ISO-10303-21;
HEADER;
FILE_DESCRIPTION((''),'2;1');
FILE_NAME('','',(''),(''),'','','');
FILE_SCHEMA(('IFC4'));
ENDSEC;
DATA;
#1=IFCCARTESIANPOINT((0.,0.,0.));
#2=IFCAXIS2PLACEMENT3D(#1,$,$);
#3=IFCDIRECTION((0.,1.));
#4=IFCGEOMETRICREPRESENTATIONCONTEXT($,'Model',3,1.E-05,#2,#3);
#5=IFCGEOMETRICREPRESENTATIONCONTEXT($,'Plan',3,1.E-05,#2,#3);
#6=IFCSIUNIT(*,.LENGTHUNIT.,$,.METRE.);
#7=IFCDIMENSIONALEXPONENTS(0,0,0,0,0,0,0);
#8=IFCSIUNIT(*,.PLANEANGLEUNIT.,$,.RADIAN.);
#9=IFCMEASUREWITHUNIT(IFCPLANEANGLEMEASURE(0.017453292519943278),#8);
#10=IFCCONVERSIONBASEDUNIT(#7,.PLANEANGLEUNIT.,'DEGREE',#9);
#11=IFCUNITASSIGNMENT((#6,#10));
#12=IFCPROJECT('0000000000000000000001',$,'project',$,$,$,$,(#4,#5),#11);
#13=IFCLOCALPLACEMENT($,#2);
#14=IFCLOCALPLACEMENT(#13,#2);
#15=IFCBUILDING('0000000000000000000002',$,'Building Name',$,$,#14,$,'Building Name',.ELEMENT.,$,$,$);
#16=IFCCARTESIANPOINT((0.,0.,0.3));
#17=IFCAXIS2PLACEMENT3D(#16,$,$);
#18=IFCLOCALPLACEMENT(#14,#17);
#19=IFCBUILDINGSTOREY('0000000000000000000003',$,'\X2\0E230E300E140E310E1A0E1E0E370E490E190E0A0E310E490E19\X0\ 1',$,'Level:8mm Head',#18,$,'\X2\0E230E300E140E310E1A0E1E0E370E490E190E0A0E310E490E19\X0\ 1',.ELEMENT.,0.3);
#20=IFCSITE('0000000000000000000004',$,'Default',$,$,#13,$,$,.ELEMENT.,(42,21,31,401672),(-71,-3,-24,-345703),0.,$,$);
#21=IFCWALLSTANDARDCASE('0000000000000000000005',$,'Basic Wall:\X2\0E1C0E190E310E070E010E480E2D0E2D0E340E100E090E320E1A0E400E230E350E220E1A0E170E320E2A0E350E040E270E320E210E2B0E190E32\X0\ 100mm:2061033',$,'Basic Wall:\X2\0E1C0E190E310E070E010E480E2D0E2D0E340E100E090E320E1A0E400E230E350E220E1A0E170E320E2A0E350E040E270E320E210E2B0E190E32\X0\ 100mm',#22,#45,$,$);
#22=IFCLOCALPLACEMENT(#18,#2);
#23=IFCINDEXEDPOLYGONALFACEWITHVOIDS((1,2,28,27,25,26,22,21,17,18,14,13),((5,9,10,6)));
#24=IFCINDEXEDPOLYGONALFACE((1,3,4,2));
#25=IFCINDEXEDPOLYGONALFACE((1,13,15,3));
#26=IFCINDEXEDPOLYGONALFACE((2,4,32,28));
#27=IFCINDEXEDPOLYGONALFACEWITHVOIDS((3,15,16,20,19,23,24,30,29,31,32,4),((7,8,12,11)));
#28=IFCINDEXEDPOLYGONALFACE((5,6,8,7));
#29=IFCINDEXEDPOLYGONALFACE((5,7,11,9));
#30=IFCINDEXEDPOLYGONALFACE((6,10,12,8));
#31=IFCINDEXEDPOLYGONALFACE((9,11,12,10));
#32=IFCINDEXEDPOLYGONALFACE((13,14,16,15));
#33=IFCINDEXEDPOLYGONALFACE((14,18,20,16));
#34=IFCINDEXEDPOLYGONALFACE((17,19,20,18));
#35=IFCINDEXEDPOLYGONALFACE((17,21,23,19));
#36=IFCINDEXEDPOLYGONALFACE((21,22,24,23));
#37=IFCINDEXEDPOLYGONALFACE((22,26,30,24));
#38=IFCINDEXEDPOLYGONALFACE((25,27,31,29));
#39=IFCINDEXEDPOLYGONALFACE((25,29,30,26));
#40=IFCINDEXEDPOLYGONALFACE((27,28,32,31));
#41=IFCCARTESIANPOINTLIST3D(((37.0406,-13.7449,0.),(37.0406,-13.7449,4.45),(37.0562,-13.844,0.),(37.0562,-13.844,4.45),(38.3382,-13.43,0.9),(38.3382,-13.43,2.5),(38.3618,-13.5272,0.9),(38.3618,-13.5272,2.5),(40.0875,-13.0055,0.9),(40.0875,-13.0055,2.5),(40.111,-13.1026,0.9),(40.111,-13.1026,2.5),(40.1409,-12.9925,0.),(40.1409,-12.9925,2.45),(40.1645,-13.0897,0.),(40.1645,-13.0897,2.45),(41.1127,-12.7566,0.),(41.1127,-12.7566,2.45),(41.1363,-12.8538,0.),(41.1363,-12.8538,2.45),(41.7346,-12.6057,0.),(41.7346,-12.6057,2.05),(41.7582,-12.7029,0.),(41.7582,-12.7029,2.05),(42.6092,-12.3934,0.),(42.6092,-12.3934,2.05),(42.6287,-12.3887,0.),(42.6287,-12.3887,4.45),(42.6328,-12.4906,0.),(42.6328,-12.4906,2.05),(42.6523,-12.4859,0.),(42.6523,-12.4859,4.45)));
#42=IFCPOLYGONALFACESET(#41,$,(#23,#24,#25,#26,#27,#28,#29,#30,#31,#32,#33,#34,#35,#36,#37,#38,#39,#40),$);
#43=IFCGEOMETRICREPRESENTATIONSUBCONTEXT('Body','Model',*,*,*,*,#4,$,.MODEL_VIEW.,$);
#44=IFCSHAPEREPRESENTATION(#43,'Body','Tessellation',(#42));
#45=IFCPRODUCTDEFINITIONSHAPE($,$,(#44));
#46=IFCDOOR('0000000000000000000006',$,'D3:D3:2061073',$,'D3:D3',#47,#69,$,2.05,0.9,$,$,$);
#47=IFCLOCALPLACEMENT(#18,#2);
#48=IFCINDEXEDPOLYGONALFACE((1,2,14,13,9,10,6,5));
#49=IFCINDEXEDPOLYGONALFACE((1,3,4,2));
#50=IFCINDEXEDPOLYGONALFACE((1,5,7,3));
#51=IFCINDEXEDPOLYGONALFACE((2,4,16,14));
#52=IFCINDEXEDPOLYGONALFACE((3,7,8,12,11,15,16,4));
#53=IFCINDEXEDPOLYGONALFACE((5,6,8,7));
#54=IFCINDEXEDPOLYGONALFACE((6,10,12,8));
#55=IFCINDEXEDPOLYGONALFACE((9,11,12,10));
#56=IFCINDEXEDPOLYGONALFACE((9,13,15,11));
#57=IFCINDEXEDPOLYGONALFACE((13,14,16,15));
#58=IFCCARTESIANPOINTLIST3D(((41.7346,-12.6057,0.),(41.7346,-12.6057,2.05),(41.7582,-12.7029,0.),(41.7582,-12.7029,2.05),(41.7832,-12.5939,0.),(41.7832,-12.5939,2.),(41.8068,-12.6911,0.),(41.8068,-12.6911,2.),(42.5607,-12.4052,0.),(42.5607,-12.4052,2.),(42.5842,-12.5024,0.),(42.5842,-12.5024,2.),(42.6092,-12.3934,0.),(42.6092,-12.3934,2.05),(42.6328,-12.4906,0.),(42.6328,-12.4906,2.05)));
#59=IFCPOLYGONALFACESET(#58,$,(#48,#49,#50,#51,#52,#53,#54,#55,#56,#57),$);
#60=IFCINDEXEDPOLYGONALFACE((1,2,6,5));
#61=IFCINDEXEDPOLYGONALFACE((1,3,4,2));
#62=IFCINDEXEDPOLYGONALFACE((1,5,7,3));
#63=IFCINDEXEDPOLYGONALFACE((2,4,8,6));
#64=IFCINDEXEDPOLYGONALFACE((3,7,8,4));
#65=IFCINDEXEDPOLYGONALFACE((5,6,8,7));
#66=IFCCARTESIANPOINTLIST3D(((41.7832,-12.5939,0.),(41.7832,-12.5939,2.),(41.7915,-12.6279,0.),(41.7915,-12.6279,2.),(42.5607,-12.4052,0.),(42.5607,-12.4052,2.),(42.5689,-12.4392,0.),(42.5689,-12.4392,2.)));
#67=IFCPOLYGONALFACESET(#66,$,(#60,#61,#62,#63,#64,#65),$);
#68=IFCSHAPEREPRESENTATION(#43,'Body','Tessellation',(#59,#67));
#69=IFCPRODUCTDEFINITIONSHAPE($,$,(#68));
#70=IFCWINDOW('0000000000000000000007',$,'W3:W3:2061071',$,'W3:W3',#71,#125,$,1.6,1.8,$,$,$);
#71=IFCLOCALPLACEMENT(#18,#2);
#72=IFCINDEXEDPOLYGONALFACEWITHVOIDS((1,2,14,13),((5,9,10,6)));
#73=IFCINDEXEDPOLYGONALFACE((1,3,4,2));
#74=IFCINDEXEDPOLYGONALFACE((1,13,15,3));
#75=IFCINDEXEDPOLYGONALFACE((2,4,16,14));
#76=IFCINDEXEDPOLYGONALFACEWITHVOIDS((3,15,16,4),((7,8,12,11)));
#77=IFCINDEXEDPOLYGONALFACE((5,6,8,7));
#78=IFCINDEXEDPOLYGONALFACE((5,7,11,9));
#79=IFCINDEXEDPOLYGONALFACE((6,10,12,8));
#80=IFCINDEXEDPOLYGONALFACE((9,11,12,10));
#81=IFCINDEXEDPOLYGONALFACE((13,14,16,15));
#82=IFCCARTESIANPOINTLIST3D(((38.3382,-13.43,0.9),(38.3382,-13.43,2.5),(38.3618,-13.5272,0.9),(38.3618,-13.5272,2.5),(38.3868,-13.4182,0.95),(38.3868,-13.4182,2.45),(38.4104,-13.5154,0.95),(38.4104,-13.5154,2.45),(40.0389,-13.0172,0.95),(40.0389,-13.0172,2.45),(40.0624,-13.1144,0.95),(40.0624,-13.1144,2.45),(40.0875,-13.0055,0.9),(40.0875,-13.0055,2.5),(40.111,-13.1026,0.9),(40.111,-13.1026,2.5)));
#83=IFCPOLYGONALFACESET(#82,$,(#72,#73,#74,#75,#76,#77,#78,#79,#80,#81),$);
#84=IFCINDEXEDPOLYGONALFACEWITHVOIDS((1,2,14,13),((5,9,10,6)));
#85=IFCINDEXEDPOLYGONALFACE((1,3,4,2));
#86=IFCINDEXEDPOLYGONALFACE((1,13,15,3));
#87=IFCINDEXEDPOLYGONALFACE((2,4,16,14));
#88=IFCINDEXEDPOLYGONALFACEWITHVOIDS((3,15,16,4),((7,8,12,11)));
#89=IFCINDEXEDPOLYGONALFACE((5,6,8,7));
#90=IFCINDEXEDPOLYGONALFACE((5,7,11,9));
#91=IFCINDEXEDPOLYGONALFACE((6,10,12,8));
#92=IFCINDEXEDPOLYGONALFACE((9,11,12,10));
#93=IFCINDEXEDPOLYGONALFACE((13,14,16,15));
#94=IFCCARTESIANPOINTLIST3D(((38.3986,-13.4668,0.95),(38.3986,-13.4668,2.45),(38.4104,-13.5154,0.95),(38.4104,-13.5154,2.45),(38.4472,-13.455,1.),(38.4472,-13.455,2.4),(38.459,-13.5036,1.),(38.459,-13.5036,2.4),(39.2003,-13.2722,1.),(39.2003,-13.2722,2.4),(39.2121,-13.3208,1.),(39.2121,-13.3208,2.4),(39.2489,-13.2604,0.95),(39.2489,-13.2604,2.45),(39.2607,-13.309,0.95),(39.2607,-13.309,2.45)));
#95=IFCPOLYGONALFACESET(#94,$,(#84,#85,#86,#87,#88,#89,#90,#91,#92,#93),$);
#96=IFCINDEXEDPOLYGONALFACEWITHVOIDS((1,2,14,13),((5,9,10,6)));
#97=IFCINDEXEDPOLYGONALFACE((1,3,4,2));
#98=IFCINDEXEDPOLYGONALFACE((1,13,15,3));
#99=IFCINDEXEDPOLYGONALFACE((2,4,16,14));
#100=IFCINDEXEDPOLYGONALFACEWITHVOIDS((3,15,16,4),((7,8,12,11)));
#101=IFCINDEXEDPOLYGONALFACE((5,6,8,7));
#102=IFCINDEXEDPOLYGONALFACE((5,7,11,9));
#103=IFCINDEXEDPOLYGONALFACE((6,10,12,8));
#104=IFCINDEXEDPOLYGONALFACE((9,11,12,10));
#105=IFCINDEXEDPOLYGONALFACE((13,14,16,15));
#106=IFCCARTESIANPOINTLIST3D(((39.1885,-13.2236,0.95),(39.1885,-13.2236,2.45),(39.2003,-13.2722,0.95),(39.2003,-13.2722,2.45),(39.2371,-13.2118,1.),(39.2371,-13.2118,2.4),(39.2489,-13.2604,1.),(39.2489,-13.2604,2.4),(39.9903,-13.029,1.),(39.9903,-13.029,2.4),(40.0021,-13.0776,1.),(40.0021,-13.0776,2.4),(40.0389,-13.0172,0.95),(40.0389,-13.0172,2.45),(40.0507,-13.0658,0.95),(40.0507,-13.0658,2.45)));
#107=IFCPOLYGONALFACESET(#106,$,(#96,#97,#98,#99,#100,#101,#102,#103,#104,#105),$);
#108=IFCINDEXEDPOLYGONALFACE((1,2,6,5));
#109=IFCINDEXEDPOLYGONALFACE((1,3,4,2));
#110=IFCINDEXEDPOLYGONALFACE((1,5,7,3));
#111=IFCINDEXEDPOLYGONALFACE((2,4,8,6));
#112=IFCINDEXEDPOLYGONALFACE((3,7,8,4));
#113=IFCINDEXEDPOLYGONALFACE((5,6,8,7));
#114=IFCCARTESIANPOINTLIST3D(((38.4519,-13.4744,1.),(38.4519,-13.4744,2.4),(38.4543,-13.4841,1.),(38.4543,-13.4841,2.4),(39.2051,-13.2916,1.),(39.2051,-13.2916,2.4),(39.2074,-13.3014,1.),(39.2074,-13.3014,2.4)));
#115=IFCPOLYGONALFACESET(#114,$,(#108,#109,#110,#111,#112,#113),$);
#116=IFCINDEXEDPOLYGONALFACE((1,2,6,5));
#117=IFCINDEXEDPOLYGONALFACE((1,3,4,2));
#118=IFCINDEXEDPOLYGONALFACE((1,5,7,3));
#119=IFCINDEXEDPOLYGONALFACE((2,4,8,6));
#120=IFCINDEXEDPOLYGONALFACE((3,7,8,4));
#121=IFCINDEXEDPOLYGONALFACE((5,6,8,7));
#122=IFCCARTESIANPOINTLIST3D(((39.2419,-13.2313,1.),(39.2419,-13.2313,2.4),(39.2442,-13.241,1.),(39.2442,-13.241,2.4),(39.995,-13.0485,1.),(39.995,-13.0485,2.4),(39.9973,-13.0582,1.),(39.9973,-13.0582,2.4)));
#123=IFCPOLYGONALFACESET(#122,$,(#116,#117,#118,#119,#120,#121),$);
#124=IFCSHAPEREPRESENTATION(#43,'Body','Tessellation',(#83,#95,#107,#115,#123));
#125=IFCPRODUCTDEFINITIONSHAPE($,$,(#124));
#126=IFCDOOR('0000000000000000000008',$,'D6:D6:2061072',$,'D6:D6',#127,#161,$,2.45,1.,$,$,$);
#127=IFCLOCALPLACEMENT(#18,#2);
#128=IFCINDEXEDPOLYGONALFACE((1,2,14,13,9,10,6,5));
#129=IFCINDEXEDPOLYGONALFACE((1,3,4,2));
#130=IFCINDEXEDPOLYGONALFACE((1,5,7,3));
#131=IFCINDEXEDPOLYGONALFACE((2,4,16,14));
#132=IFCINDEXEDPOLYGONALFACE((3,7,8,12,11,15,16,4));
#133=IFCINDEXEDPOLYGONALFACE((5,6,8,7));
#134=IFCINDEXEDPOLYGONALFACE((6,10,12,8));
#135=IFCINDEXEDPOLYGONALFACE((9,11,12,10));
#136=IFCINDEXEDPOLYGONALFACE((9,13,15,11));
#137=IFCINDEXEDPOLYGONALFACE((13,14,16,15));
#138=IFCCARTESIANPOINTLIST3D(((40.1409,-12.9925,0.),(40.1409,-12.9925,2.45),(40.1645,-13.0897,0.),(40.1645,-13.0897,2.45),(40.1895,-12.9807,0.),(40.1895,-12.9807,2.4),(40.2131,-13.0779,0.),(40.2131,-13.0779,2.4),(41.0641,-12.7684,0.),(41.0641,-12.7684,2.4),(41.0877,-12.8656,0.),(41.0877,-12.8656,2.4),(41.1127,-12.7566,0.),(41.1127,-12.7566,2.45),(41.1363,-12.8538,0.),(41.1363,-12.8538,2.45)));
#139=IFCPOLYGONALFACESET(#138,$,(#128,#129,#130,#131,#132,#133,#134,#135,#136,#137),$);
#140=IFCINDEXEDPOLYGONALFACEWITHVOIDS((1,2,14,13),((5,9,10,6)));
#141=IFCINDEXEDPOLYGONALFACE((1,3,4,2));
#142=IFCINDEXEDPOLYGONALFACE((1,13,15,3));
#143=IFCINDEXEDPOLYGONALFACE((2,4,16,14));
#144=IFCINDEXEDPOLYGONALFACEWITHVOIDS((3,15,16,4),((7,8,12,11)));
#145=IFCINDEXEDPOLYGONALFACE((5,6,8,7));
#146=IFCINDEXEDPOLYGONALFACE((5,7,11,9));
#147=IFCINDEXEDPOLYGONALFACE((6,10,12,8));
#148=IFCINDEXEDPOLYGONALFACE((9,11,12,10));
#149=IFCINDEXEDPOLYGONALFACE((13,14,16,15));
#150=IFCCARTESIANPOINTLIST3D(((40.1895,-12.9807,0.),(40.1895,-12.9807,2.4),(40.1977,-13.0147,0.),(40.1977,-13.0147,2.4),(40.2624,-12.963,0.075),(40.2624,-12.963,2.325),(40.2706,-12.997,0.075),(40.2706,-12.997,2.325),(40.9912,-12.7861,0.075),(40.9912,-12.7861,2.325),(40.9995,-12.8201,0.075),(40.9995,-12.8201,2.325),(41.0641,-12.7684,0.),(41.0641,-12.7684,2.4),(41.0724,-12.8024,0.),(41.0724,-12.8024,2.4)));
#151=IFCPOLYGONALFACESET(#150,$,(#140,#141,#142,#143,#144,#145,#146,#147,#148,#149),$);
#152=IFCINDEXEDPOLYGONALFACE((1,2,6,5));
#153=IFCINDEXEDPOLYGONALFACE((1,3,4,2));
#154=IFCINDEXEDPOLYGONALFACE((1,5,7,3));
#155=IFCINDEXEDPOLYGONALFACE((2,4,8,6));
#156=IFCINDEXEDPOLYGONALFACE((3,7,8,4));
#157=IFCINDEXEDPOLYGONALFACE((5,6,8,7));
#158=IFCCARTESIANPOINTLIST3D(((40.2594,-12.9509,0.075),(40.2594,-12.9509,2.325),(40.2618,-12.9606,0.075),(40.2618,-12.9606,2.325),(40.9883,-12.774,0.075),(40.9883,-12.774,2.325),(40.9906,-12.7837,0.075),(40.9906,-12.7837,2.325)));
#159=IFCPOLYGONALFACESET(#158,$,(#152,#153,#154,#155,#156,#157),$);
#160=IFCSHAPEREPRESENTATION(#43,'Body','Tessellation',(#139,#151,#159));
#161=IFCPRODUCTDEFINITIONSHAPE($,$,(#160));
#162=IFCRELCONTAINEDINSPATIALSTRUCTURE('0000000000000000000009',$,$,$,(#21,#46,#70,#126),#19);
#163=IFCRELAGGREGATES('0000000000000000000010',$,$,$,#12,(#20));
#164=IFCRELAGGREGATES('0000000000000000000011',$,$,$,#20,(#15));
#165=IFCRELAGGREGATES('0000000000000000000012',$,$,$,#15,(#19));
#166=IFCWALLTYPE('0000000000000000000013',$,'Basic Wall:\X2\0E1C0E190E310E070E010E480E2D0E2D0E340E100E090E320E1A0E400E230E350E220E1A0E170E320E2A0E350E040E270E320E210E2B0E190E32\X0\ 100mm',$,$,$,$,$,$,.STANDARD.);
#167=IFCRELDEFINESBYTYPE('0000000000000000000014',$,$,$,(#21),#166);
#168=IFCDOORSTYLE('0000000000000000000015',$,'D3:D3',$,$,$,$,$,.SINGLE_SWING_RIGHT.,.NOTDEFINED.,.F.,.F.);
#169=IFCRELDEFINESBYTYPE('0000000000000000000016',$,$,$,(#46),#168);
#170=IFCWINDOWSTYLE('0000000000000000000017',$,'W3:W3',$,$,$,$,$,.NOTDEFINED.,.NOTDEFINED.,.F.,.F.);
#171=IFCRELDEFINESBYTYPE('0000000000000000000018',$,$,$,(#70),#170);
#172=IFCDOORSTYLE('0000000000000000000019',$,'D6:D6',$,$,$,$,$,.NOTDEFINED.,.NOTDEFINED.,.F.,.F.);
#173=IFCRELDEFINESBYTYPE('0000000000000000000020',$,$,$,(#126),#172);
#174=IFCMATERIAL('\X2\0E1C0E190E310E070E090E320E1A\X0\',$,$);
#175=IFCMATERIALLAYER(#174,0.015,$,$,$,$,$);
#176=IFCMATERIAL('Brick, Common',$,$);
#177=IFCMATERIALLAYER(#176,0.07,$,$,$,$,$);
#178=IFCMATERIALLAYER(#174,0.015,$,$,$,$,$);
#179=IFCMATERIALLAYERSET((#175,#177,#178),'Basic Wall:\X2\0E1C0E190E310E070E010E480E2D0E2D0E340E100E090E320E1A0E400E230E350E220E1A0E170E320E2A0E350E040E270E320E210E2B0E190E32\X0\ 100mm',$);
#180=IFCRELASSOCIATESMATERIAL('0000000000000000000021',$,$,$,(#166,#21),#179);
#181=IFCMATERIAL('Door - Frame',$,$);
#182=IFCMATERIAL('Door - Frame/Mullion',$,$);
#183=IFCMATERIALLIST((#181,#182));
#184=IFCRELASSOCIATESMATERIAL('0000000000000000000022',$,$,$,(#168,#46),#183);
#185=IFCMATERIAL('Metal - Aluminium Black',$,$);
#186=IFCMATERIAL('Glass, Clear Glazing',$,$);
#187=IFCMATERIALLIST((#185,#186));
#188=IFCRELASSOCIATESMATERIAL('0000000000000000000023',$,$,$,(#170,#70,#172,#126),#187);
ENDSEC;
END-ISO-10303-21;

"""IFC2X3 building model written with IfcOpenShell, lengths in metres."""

from ifc_helpers import new_model, entity, si_unit, converted_unit, direction, frame, frame_2d, origin, origin_2d_with_axis, place, context, subcontext, project, spatial, polyline, rectangle, outline, extrude, clip, halfspace, source, transform, mapped, material, material_list, layer, layer_set, layer_usage, type_object, type_shapes, element, fill, save


model = new_model("IFC2X3")

# Units and contexts
model_context = context("Model", 3, precision=1e-05, world=origin(), true_north=direction((0.0, 1.0)))
plan_context = context("Plan", 3, precision=1e-05, world=origin(), true_north=direction((0.0, 1.0)))
body_context = subcontext(model_context, "Body", "Model", "MODEL_VIEW")
ifc_project = project(units=[si_unit("LENGTHUNIT", "METRE"), converted_unit("PLANEANGLEUNIT", "DEGREE", entity("IfcPlaneAngleMeasure", 0.017453292519943278), si_unit("PLANEANGLEUNIT", "RADIAN"), dimensions=[0, 0, 0, 0, 0, 0, 0])], contexts=[model_context, plan_context])

# Site, building, storey
site_placement = place(None, origin())
site = spatial("IfcSite", under=ifc_project, at=site_placement, Name="Default", CompositionType="ELEMENT", RefLatitude=(42, 21, 31, 401672), RefLongitude=(-71, -3, -24, -345703), RefElevation=0.0)
building_placement = place(site_placement, origin())
building = spatial("IfcBuilding", under=site, at=building_placement, Name="Building Name", LongName="Building Name", CompositionType="ELEMENT")
storey_placement = place(building_placement, frame((0.0, 0.0, 0.3)))
storey = spatial("IfcBuildingStorey", under=building, at=storey_placement, Name="ระดับพื้นชั้น 1", ObjectType="Level:8mm Head", LongName="ระดับพื้นชั้น 1", CompositionType="ELEMENT", Elevation=0.3)

# Shared definitions
ifc_material_1 = material(Name="Glass, Clear Glazing")

# Shared definitions
ifc_material_2 = material(Name="ผนังฉาบ")
ifc_layer_1 = layer(ifc_material_2, 0.015)
ifc_material_3 = material(Name="Brick, Common")
ifc_layer_2 = layer(ifc_material_3, 0.07)
ifc_layer_3 = layer(ifc_material_2, 0.015)
ifc_layer_set = layer_set([ifc_layer_1, ifc_layer_2, ifc_layer_3], Name="Basic Wall:ผนังก่ออิฐฉาบเรียบทาสีความหนา 100mm")
wall_type = type_object("IfcWallType", Name="Basic Wall:ผนังก่ออิฐฉาบเรียบทาสีความหนา 100mm", PredefinedType="STANDARD", material=ifc_layer_set)
ifc_material_4 = material(Name="Door - Frame")
ifc_material_5 = material(Name="Door - Frame/Mullion")
ifc_material_list_1 = material_list([ifc_material_4, ifc_material_5])
door_style_1 = type_object("IfcDoorStyle", Name="D3:D3", ConstructionType="NOTDEFINED", OperationType="SINGLE_SWING_RIGHT", ParameterTakesPrecedence=False, Sizeable=False, material=ifc_material_list_1)
shared_shape_1 = source(origin(), body_context, "Body", "SweptSolid", [
    extrude(outline(polyline([(-0.45, -1.0125), (-0.4, -1.0125), (-0.4, 0.9875), (0.4, 0.9875), (0.4, -1.0125), (0.45, -1.0125), (0.45, 1.0375), (-0.45, 1.0375), (-0.45, -1.0125)])), frame((0.45, 0.1, 1.0125), z_axis=(0.0, -1.0, 0.0), x_axis=(1.0, 0.0, 0.0)), (0.0, 0.0, 1.0), 0.1),
    extrude(rectangle(XDim=0.035, YDim=0.8, at=origin_2d_with_axis()), frame((0.45, 0.0825, 0.0), z_axis=(0.0, 0.0, 1.0), x_axis=(0.0, -1.0, 0.0)), (0.0, 0.0, 1.0), 2.0),
])
type_shapes(door_style_1, [shared_shape_1])

# Wall, openings, doors, window
ifc_layer_usage_1 = layer_usage(ifc_layer_set, "AXIS2", "POSITIVE", -0.05)
wall_1_placement = place(storey_placement, frame((37.0444, -13.7954, 0.0), z_axis=(0.0, 0.0, 1.0), x_axis=(0.97179, 0.235849, 0.0)))
wall_1 = element("IfcWallStandardCase", 1, at=wall_1_placement, inside=storey, type_object=wall_type, material=ifc_layer_usage_1, Name="Basic Wall:ผนังก่ออิฐฉาบเรียบทาสีความหนา 100mm:2061033", ObjectType="Basic Wall:ผนังก่ออิฐฉาบเรียบทาสีความหนา 100mm", context=body_context, shape_type="Clipping", body=[
    clip(extrude(outline(polyline([(5.7585, -0.05), (5.7585, 0.05), (4.3098, 0.05), (4.209, 0.05), (0.0082, 0.05), (0.0, -0.05), (5.7585, -0.05)])), origin(), (0.0, 0.0, 1.0), 4.45), halfspace(frame((0.0, 0.0, -0.15)), True)),
])
opening_1_placement = place(wall_1_placement, frame((4.8385, -0.05, 0.0)))
opening_1 = element("IfcOpeningElement", 2, at=opening_1_placement, cuts=wall_1, ObjectType="Opening", context=body_context, shape_type="SweptSolid", body=[
    extrude(rectangle(XDim=2.05, YDim=0.9, at=frame_2d((1.025, 0.45), x_axis=(1.0, 0.0))), frame((0.0, 0.0, 0.0), z_axis=(0.0, 1.0, 0.0), x_axis=(0.0, 0.0, 1.0)), (0.0, 0.0, 1.0), 0.1),
])
opening_2_placement = place(wall_1_placement, frame((3.1985, -0.05, 0.0)))
opening_2 = element("IfcOpeningElement", 3, at=opening_2_placement, cuts=wall_1, ObjectType="Opening", context=body_context, shape_type="SweptSolid", body=[
    extrude(rectangle(XDim=2.45, YDim=1.0, at=frame_2d((1.225, 0.5), x_axis=(1.0, 0.0))), frame((0.0, 0.0, 0.0), z_axis=(0.0, 1.0, 0.0), x_axis=(0.0, 0.0, 1.0)), (0.0, 0.0, 1.0), 0.1),
])
opening_3_placement = place(wall_1_placement, frame((3.1435, 0.05, 0.9)))
opening_3 = element("IfcOpeningElement", 4, at=opening_3_placement, cuts=wall_1, ObjectType="Opening", context=body_context, shape_type="SweptSolid", body=[
    extrude(rectangle(XDim=1.6, YDim=1.8, at=frame_2d((0.8, 0.9), x_axis=(1.0, 0.0))), frame((0.0, 0.0, 0.0), z_axis=(0.0, -1.0, 0.0), x_axis=(0.0, 0.0, 1.0)), (0.0, 0.0, 1.0), 0.1),
])
door_1_placement = place(opening_1_placement, origin())
door_1 = element("IfcDoor", 5, at=door_1_placement, inside=storey, type_object=door_style_1, material=ifc_material_list_1, Name="D3:D3:2061073", ObjectType="D3:D3", OverallHeight=2.05, OverallWidth=0.9, context=body_context, shape_type="MappedRepresentation", body=[
    mapped(shared_shape_1, transform((0.0, 0.0, 0.0), scale=1.0)),
])
fill(opening_1, door_1)
ifc_material_6 = material(Name="Metal - Aluminium Black")
ifc_material_list_2 = material_list([ifc_material_6, ifc_material_1])
window_style = type_object("IfcWindowStyle", Name="W3:W3", ConstructionType="NOTDEFINED", OperationType="NOTDEFINED", ParameterTakesPrecedence=False, Sizeable=False, material=ifc_material_list_2)
shared_shape_2 = source(origin(), body_context, "Body", "SweptSolid", [
    extrude(outline(polyline([(-0.8, -0.9), (0.8, -0.9), (0.8, 0.9), (-0.8, 0.9), (-0.8, -0.9)]), holes=[polyline([(0.75, -0.85), (-0.75, -0.85), (-0.75, 0.85), (0.75, 0.85), (0.75, -0.85)])]), frame((0.9, 0.0, 0.8), z_axis=(0.0, 1.0, 0.0), x_axis=(0.0, 0.0, 1.0)), (0.0, 0.0, 1.0), 0.1),
    extrude(outline(polyline([(-0.75, -0.4375), (0.75, -0.4375), (0.75, 0.4375), (-0.75, 0.4375), (-0.75, -0.4375)]), holes=[polyline([(0.7, -0.3875), (-0.7, -0.3875), (-0.7, 0.3875), (0.7, 0.3875), (0.7, -0.3875)])]), frame((1.3125, 0.05, 0.8), z_axis=(0.0, 1.0, 0.0), x_axis=(0.0, 0.0, -1.0)), (0.0, 0.0, 1.0), 0.05),
    extrude(outline(polyline([(-0.75, -0.4375), (0.75, -0.4375), (0.75, 0.4375), (-0.75, 0.4375), (-0.75, -0.4375)]), holes=[polyline([(0.7, -0.3875), (-0.7, -0.3875), (-0.7, 0.3875), (0.7, 0.3875), (0.7, -0.3875)])]), frame((0.4875, 0.0, 0.8), z_axis=(0.0, 1.0, 0.0), x_axis=(0.0, 0.0, -1.0)), (0.0, 0.0, 1.0), 0.05),
    extrude(rectangle(XDim=0.01, YDim=0.775, at=frame_2d((0.0, 0.0), x_axis=(1.0, 0.0))), frame((1.3125, 0.075, 0.1), z_axis=(0.0, 0.0, 1.0), x_axis=(0.0, -1.0, 0.0)), (0.0, 0.0, 1.0), 1.4),
    extrude(rectangle(XDim=0.01, YDim=0.775, at=frame_2d((0.0, 0.0), x_axis=(1.0, 0.0))), frame((0.4875, 0.025, 0.1), z_axis=(0.0, 0.0, 1.0), x_axis=(0.0, -1.0, 0.0)), (0.0, 0.0, 1.0), 1.4),
])
type_shapes(window_style, [shared_shape_2])
window_1_placement = place(opening_3_placement, frame((0.0, 0.0, 0.0), z_axis=(0.0, 0.0, 1.0), x_axis=(-1.0, 0.0, 0.0)))
window_1 = element("IfcWindow", 6, at=window_1_placement, inside=storey, type_object=window_style, material=ifc_material_list_2, Name="W3:W3:2061071", ObjectType="W3:W3", OverallHeight=1.6, OverallWidth=1.8, context=body_context, shape_type="MappedRepresentation", body=[
    mapped(shared_shape_2, transform((0.0, 0.0, 0.0), scale=1.0)),
])
fill(opening_3, window_1)
door_style_2 = type_object("IfcDoorStyle", Name="D6:D6", ConstructionType="NOTDEFINED", OperationType="NOTDEFINED", ParameterTakesPrecedence=False, Sizeable=False, material=ifc_material_list_2)
shared_shape_3 = source(origin(), body_context, "Body", "SweptSolid", [
    extrude(outline(polyline([(-1.2125, -0.45), (-1.2125, -0.5), (1.2375, -0.5), (1.2375, 0.5), (-1.2125, 0.5), (-1.2125, 0.45), (1.1875, 0.45), (1.1875, -0.45), (-1.2125, -0.45)])), frame((0.5, 0.0, 1.2125), z_axis=(0.0, -1.0, 0.0), x_axis=(0.0, 0.0, 1.0)), (0.0, 0.0, -1.0), 0.1),
    extrude(outline(polyline([(-1.2, -0.45), (1.2, -0.45), (1.2, 0.45), (-1.2, 0.45), (-1.2, -0.45)]), holes=[polyline([(1.125, -0.375), (-1.125, -0.375), (-1.125, 0.375), (1.125, 0.375), (1.125, -0.375)])]), frame((0.5, 0.065, 1.2), z_axis=(0.0, 1.0, 0.0), x_axis=(0.0, 0.0, 1.0)), (0.0, 0.0, 1.0), 0.035),
    extrude(rectangle(XDim=0.01, YDim=0.75, at=origin_2d_with_axis()), frame((0.5, 0.1075, 0.075), z_axis=(0.0, 0.0, 1.0), x_axis=(0.0, 1.0, 0.0)), (0.0, 0.0, 1.0), 2.25),
])
type_shapes(door_style_2, [shared_shape_3])
door_2_placement = place(opening_2_placement, origin())
door_2 = element("IfcDoor", 7, at=door_2_placement, inside=storey, type_object=door_style_2, material=ifc_material_list_2, Name="D6:D6:2061072", ObjectType="D6:D6", OverallHeight=2.45, OverallWidth=1.0, context=body_context, shape_type="MappedRepresentation", body=[
    mapped(shared_shape_3, transform((0.0, 0.0, 0.0), scale=1.0)),
])
fill(opening_2, door_2)

save(model, "model.ifc")
